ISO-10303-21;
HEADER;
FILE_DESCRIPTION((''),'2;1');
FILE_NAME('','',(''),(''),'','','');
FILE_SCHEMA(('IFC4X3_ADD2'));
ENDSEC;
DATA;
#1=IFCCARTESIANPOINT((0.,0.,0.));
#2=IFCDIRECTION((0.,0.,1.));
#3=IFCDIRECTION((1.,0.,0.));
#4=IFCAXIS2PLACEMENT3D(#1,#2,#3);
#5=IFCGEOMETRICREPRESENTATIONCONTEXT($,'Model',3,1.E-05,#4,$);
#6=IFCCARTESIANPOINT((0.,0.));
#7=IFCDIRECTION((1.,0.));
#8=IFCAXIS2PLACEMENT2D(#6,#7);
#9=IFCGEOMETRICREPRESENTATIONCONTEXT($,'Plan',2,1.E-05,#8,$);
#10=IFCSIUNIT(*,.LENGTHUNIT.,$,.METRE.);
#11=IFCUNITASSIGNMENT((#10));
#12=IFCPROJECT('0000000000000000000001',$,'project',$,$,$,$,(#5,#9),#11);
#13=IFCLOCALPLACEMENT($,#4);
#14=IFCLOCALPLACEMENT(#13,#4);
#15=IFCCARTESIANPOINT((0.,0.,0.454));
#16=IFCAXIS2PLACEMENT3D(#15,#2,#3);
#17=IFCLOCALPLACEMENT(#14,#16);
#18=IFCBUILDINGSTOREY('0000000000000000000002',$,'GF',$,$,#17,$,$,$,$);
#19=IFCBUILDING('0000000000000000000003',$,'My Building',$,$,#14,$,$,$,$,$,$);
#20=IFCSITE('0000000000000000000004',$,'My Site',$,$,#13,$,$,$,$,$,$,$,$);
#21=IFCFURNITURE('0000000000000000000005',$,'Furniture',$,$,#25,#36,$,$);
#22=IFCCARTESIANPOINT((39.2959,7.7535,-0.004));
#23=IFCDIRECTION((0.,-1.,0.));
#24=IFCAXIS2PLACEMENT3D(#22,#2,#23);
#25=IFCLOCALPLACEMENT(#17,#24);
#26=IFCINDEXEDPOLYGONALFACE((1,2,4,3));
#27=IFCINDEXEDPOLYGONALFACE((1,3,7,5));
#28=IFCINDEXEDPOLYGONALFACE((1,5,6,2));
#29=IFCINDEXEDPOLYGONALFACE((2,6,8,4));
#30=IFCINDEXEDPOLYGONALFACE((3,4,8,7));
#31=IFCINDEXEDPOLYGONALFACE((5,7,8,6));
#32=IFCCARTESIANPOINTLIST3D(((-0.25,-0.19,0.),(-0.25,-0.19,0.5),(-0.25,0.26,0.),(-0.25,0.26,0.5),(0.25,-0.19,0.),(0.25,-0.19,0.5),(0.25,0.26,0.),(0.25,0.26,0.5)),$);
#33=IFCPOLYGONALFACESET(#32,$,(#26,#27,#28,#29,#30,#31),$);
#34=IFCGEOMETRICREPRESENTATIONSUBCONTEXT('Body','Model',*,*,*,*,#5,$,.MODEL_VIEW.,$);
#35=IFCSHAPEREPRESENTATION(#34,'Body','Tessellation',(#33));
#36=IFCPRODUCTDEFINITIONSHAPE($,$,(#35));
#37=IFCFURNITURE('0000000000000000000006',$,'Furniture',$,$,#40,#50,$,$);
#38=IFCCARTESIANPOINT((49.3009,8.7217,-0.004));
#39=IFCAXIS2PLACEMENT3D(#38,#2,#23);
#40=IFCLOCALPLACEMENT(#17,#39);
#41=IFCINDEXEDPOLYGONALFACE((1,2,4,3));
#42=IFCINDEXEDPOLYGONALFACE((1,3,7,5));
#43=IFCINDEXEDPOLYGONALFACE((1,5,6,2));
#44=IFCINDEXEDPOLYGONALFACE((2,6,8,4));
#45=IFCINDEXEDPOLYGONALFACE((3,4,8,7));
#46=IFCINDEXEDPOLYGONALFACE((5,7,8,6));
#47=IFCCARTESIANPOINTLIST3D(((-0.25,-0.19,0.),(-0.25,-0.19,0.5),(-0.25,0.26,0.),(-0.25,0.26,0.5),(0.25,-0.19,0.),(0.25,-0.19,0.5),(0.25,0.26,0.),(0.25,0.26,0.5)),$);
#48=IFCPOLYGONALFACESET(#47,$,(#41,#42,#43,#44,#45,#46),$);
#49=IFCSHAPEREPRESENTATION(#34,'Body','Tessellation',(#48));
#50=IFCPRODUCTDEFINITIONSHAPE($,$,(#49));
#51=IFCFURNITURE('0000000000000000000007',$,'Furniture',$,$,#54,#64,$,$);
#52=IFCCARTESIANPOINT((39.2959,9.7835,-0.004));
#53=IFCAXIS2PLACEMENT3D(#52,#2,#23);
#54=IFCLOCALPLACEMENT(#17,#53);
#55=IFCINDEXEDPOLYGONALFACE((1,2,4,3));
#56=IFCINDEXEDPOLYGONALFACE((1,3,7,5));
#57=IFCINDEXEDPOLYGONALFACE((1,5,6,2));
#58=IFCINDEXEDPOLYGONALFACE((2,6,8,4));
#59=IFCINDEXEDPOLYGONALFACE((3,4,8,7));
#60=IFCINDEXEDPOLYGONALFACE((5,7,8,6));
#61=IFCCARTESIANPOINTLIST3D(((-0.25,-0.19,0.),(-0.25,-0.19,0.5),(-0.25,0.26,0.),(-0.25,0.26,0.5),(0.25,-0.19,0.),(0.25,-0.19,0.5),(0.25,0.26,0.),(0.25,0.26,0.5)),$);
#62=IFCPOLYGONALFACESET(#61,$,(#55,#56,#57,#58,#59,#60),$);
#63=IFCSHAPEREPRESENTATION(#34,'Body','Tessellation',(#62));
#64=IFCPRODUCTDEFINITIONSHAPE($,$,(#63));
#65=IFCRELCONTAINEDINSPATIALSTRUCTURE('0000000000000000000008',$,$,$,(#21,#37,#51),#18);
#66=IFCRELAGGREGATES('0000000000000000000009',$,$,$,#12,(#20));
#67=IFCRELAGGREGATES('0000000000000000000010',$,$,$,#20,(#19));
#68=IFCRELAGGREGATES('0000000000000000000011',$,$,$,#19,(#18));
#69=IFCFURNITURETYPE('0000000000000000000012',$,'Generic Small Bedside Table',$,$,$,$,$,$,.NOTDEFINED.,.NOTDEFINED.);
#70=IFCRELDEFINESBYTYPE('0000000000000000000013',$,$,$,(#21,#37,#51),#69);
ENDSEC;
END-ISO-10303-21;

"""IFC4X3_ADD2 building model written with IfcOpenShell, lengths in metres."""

from ifc_helpers import new_model, entity, si_unit, frame, origin_with_axes, origin_2d_with_axis, place, context, subcontext, project, spatial, line, indexed_curve, outline, extrude, shape, source, transform, mapped, type_object, type_shapes, element, save


model = new_model("IFC4X3_ADD2")

# Units and contexts
model_context = context("Model", 3, precision=1e-05, world=origin_with_axes())
plan_context = context("Plan", 2, precision=1e-05, world=origin_2d_with_axis())
body_context_1 = subcontext(model_context, "Body", "Model", "MODEL_VIEW")
body_context_2 = subcontext(plan_context, "Body", "Plan", "PLAN_VIEW")
ifc_project = project(units=[si_unit("LENGTHUNIT", "METRE")], contexts=[model_context, plan_context])

# Site, building, storey
site_placement = place(None, origin_with_axes())
site = spatial("IfcSite", under=ifc_project, at=site_placement, Name="My Site")
building_placement = place(site_placement, origin_with_axes())
building = spatial("IfcBuilding", under=site, at=building_placement, Name="My Building")
storey_placement = place(building_placement, frame((0.0, 0.0, 0.454), z_axis=(0.0, 0.0, 1.0), x_axis=(1.0, 0.0, 0.0)))
storey = spatial("IfcBuildingStorey", under=building, at=storey_placement, Name="GF")

# Furniture
furniture_type_1 = type_object("IfcFurnitureType", Name="Generic Small Bedside Table", AssemblyPlace="NOTDEFINED", PredefinedType="NOTDEFINED")
shared_shape_1 = source(origin_with_axes(), body_context_1, "Body", "SweptSolid", [
    extrude(outline(indexed_curve([(0.5, 0.45), (0.5, 0.0), (0.0, 0.0), (0.0, 0.45)], segments=[line(4, 1), line(1, 2), line(2, 3), line(3, 4)], self_intersect=False)), frame((-0.25, -0.19, 0.0), z_axis=(0.0, 0.0, 1.0), x_axis=(1.0, 0.0, 0.0)), (0.0, 0.0, 1.0), 0.5),
])
shared_shape_2 = source(origin_with_axes(), body_context_2, "Body", "Annotation2D", [
    entity("IfcGeometricCurveSet", [entity("IfcIndexedPolyCurve", entity("IfcCartesianPointList2D", [[-0.25, -0.19], [0.25, -0.19], [0.25, 0.26], [-0.25, 0.26]]), [entity("IfcLineIndex", [1, 2]), entity("IfcLineIndex", [2, 3]), entity("IfcLineIndex", [3, 4]), entity("IfcLineIndex", [4, 1])])]),
])
type_shapes(furniture_type_1, [shared_shape_1, shared_shape_2])
for number, where, z_axis, x_axis, name in (
    (1, (39.2959, 7.7535, -0.004), (0.0, 0.0, 1.0), (0.0, -1.0, 0.0), "Furniture"),
    (2, (49.3009, 8.7217, -0.004), (0.0, 0.0, 1.0), (0.0, -1.0, 0.0), "Furniture"),
    (3, (39.2959, 9.7835, -0.004), (0.0, 0.0, 1.0), (0.0, -1.0, 0.0), "Furniture"),
):
    element("IfcFurniture", number, at=place(storey_placement, frame(where, z_axis=z_axis, x_axis=x_axis)), inside=storey, type_object=furniture_type_1, Name=name, shapes=[
        shape(body_context_1, "Body", "MappedRepresentation", [mapped(shared_shape_1, transform((0.0, 0.0, 0.0), x_axis=(1.0, 0.0, 0.0), y_axis=(0.0, 1.0, 0.0), z_axis=(0.0, 0.0, 1.0), scale=1.0))]),
        shape(body_context_2, "Body", "MappedRepresentation", [mapped(shared_shape_2, transform((0.0, 0.0, 0.0), x_axis=(1.0, 0.0, 0.0), y_axis=(0.0, 1.0, 0.0), z_axis=(0.0, 0.0, 1.0), scale=1.0))]),
    ])

save(model, "model.ifc")
